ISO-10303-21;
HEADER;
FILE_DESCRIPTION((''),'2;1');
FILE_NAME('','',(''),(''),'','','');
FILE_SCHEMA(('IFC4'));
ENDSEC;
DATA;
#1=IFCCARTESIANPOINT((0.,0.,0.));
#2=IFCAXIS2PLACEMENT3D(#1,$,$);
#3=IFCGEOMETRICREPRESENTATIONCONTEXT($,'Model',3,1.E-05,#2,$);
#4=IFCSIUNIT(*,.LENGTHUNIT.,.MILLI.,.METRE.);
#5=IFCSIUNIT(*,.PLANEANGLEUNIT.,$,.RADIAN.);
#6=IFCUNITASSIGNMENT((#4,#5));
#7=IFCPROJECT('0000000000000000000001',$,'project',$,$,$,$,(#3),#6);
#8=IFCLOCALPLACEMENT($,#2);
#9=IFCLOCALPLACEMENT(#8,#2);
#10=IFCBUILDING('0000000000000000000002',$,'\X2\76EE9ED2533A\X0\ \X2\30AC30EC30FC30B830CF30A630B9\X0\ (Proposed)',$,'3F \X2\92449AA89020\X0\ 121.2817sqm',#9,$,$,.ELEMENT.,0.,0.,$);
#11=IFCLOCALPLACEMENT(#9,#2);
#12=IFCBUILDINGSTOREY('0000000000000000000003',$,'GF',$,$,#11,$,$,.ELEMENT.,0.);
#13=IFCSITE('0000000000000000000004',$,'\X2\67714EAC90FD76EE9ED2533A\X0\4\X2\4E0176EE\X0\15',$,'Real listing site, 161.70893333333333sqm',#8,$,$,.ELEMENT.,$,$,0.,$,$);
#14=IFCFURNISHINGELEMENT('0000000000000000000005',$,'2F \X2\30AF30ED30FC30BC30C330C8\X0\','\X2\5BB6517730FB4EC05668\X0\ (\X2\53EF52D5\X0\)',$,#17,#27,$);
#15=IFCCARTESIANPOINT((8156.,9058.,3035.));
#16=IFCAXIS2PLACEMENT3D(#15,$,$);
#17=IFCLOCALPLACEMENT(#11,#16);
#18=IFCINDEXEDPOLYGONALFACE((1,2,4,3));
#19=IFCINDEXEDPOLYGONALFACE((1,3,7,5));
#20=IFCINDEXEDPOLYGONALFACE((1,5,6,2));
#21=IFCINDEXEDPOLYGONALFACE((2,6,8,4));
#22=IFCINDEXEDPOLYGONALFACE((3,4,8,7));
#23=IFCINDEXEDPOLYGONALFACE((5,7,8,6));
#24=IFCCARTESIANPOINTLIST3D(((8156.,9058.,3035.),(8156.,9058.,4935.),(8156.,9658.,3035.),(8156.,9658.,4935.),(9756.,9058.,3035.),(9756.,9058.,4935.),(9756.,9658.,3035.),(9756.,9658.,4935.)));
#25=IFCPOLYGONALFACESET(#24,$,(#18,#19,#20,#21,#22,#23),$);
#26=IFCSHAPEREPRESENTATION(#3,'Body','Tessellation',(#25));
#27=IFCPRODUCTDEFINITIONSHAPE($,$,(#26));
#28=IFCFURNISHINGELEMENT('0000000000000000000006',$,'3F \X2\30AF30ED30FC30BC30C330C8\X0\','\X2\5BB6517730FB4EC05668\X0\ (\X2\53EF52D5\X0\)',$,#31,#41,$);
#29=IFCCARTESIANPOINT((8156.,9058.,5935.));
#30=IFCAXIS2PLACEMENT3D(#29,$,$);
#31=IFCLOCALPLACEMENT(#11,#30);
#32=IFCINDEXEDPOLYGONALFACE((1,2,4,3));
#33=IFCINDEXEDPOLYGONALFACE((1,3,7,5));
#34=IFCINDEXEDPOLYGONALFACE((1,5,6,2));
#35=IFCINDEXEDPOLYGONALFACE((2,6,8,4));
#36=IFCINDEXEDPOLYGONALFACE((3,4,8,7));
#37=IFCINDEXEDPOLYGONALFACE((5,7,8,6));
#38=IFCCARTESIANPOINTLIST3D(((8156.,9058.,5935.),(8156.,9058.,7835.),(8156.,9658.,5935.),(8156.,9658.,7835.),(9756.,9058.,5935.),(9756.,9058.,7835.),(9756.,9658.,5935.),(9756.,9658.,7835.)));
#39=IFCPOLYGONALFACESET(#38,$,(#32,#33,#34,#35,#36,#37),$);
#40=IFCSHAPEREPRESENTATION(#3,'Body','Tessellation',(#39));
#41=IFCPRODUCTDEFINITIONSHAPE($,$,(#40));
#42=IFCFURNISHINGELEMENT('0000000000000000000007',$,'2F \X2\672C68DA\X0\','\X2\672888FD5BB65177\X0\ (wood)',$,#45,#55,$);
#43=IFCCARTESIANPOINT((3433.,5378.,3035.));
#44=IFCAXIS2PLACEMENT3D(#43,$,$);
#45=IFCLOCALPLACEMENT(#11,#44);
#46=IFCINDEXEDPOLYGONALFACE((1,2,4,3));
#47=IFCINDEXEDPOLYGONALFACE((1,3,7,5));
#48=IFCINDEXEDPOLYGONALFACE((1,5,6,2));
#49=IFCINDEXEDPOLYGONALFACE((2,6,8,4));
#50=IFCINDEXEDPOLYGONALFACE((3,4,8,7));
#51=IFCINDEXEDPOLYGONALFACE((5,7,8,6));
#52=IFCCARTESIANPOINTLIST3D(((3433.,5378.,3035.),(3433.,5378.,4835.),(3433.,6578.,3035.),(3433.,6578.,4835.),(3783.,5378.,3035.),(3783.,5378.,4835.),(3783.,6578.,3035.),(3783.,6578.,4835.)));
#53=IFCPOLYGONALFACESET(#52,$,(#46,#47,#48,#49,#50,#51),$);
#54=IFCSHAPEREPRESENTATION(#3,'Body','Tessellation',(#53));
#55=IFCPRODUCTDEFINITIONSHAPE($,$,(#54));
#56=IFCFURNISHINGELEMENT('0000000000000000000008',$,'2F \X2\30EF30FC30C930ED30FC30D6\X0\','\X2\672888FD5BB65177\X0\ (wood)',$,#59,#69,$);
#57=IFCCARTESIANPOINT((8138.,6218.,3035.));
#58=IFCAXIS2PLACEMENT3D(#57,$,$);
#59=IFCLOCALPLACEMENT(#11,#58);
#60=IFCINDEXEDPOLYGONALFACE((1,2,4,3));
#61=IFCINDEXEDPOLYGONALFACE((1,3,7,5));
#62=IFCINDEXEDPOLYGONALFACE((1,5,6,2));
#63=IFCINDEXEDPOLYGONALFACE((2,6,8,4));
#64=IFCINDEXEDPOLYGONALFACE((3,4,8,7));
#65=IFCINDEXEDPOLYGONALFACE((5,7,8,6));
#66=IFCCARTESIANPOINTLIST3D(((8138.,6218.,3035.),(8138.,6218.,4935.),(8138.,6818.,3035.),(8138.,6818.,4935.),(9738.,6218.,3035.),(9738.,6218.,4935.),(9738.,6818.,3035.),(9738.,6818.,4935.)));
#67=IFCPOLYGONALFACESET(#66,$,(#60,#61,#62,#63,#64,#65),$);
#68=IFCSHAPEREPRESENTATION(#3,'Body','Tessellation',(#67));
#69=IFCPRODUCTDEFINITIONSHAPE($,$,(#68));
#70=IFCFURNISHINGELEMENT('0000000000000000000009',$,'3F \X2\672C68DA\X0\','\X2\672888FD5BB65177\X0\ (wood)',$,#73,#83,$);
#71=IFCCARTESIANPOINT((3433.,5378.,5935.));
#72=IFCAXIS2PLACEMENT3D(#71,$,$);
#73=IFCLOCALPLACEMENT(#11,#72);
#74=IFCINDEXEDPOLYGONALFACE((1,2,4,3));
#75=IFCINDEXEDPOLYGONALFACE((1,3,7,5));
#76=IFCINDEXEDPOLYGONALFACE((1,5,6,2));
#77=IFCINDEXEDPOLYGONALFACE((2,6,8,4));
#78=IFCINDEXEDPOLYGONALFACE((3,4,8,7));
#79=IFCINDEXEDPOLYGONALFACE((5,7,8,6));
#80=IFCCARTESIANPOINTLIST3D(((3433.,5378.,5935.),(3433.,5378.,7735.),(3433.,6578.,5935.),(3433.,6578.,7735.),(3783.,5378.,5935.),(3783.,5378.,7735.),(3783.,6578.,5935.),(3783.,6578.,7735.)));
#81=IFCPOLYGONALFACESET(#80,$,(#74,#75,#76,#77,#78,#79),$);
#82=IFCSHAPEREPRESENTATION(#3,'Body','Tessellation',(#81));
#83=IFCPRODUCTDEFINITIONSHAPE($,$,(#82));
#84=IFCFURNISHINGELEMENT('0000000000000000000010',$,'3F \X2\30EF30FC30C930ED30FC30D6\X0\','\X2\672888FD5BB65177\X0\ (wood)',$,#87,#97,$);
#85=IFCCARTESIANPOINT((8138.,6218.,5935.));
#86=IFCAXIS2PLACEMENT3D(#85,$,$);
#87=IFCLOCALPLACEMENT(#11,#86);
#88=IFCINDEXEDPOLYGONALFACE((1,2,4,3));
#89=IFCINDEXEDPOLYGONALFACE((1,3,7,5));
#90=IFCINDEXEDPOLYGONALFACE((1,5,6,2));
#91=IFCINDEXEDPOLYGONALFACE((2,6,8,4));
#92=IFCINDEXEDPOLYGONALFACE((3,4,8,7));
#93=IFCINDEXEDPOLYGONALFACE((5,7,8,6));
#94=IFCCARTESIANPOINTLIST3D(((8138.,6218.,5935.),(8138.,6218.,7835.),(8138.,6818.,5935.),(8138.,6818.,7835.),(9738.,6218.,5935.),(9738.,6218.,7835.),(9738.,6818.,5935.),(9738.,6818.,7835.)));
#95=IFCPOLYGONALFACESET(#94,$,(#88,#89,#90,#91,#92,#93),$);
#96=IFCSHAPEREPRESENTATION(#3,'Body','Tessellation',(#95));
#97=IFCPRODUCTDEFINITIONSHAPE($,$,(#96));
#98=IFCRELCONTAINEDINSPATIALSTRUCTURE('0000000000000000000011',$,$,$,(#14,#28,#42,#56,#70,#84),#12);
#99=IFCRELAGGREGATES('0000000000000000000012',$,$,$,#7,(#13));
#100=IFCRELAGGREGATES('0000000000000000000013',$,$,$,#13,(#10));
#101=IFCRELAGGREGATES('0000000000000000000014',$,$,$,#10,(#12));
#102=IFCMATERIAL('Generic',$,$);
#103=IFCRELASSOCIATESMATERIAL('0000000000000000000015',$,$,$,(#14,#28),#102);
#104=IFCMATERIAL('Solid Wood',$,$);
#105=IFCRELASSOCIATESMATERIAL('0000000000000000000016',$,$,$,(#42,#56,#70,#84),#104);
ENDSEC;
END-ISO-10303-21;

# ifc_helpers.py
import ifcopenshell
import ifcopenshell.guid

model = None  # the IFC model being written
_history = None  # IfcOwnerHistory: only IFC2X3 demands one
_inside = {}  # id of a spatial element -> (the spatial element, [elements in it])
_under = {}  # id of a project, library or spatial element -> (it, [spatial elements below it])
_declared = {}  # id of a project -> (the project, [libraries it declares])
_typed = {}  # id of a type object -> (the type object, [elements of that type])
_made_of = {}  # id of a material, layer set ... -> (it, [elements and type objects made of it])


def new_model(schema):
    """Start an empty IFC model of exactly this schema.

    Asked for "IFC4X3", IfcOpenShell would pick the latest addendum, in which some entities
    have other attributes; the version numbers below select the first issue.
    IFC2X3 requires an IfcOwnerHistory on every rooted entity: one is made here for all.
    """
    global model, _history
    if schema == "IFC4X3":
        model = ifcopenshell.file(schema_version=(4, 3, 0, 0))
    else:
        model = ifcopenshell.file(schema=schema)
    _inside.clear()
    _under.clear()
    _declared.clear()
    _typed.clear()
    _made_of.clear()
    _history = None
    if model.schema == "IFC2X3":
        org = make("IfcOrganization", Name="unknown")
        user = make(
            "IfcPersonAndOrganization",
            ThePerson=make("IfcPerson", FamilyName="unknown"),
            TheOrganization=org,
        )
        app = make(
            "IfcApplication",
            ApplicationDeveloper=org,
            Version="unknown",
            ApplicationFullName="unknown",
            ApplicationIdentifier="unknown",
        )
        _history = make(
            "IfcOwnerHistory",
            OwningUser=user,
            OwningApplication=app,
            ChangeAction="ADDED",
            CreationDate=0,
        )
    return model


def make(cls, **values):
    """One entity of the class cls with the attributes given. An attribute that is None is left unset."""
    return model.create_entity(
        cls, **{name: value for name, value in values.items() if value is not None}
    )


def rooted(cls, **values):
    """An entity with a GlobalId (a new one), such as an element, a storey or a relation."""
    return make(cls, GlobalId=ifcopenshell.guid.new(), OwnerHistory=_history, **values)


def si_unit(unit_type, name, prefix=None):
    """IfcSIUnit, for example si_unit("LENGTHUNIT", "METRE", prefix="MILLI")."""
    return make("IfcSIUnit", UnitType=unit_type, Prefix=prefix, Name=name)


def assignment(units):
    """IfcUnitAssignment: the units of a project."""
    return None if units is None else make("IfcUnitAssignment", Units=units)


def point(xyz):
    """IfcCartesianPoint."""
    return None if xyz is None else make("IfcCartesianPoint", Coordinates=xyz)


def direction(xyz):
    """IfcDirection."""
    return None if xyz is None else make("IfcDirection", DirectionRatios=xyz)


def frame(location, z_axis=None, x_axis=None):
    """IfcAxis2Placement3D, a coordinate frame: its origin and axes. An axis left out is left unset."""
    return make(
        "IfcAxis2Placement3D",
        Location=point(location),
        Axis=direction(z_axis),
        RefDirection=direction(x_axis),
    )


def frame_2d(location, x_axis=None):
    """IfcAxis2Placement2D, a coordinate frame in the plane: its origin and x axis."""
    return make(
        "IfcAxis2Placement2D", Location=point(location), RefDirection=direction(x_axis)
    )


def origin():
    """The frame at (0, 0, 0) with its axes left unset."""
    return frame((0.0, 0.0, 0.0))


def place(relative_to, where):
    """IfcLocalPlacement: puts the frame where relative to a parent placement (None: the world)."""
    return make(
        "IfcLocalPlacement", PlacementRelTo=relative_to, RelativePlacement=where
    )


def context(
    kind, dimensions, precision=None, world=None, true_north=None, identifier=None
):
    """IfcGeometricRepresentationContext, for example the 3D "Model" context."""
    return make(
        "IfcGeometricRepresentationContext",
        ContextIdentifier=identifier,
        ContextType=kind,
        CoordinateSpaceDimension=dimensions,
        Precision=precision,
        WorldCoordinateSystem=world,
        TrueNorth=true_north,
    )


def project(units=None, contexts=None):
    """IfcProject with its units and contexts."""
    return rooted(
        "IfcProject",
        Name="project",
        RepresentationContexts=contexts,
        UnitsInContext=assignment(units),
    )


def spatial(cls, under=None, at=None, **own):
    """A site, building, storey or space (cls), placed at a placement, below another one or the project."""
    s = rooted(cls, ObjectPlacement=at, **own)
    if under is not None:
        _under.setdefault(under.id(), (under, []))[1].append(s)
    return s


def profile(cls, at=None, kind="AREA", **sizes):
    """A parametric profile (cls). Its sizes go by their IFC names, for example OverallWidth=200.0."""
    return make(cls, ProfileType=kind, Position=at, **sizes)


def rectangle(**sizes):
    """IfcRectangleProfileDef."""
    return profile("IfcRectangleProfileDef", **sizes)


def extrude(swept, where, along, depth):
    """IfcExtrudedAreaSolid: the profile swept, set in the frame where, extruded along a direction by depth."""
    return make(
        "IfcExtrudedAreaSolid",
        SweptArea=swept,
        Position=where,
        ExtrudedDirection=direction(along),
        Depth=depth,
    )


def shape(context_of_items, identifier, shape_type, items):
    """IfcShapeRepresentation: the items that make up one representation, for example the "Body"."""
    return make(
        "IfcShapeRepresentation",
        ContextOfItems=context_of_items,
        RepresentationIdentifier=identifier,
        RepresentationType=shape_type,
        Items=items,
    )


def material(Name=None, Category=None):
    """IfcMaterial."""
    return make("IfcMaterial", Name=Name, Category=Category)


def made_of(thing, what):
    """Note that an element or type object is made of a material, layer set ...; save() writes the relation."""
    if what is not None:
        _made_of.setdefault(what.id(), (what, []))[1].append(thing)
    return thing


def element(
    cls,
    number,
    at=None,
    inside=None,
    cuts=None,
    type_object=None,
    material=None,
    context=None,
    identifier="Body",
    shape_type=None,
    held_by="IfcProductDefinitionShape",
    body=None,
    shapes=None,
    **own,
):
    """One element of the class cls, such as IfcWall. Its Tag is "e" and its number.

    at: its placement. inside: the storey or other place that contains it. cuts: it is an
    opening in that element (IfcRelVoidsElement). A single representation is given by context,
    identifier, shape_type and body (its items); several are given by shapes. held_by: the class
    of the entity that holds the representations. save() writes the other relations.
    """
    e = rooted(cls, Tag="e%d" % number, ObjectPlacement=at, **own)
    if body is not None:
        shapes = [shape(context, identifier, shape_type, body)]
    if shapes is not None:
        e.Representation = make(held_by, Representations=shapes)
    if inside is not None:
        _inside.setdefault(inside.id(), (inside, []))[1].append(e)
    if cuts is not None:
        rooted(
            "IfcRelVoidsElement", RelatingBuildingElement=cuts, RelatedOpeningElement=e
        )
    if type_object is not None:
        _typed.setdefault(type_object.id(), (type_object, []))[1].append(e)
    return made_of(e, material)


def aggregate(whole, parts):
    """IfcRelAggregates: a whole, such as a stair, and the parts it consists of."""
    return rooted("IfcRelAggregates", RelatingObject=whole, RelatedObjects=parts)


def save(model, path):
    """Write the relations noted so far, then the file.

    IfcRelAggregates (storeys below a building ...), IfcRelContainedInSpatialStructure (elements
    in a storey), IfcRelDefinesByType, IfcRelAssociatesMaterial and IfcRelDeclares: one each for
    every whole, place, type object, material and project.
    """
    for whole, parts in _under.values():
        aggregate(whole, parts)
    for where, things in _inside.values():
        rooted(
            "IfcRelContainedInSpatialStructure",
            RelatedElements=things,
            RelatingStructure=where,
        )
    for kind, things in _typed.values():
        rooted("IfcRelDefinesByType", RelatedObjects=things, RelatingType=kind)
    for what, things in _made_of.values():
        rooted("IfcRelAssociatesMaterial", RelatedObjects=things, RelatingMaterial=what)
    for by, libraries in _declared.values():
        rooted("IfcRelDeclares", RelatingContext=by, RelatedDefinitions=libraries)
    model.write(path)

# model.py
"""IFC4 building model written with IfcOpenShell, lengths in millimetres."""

from ifc_helpers import new_model, si_unit, frame, frame_2d, origin, place, context, project, spatial, rectangle, extrude, material, element, save


model = new_model("IFC4")

# Units and contexts
model_context = context("Model", 3, precision=1e-05, world=origin())
ifc_project = project(units=[si_unit("LENGTHUNIT", "METRE", prefix="MILLI"), si_unit("PLANEANGLEUNIT", "RADIAN")], contexts=[model_context])

# Site, building, storey
site_placement = place(None, origin())
site = spatial("IfcSite", under=ifc_project, at=site_placement, Name="東京都目黒区4丁目15", ObjectType="Real listing site, 161.70893333333333sqm", CompositionType="ELEMENT", RefElevation=0.0)
building_placement = place(site_placement, origin())
building = spatial("IfcBuilding", under=site, at=building_placement, Name="目黒区 ガレージハウス (Proposed)", ObjectType="3F 鉄骨造 121.2817sqm", CompositionType="ELEMENT", ElevationOfRefHeight=0.0, ElevationOfTerrain=0.0)
storey_placement = place(building_placement, origin())
storey = spatial("IfcBuildingStorey", under=building, at=storey_placement, Name="GF", CompositionType="ELEMENT", Elevation=0.0)

# Shared definitions
ifc_material_1 = material(Name="Solid Wood")

# Furnishing elements
ifc_material_2 = material(Name="Generic")
furnishing_1_placement = place(storey_placement, frame((8156.0, 9058.0, 3035.0)))
element("IfcFurnishingElement", 1, at=furnishing_1_placement, inside=storey, material=ifc_material_2, Name="2F クローゼット", Description="家具・什器 (可動)", context=model_context, shape_type="SweptSolid", body=[
    extrude(rectangle(XDim=1600.0, YDim=600.0, at=frame_2d((800.0, 300.0))), frame((8156.0, 9058.0, 3035.0)), (0.0, 0.0, 1.0), 1900.0),
])
furnishing_2_placement = place(storey_placement, frame((8156.0, 9058.0, 5935.0)))
element("IfcFurnishingElement", 2, at=furnishing_2_placement, inside=storey, material=ifc_material_2, Name="3F クローゼット", Description="家具・什器 (可動)", context=model_context, shape_type="SweptSolid", body=[
    extrude(rectangle(XDim=1600.0, YDim=600.0, at=frame_2d((800.0, 300.0))), frame((8156.0, 9058.0, 5935.0)), (0.0, 0.0, 1.0), 1900.0),
])
furnishing_3_placement = place(storey_placement, frame((3433.0, 5378.0, 3035.0)))
element("IfcFurnishingElement", 3, at=furnishing_3_placement, inside=storey, material=ifc_material_1, Name="2F 本棚", Description="木製家具 (wood)", context=model_context, shape_type="SweptSolid", body=[
    extrude(rectangle(XDim=350.0, YDim=1200.0, at=frame_2d((175.0, 600.0))), frame((3433.0, 5378.0, 3035.0)), (0.0, 0.0, 1.0), 1800.0),
])
furnishing_4_placement = place(storey_placement, frame((8138.0, 6218.0, 3035.0)))
element("IfcFurnishingElement", 4, at=furnishing_4_placement, inside=storey, material=ifc_material_1, Name="2F ワードローブ", Description="木製家具 (wood)", context=model_context, shape_type="SweptSolid", body=[
    extrude(rectangle(XDim=1600.0, YDim=600.0, at=frame_2d((800.0, 300.0))), frame((8138.0, 6218.0, 3035.0)), (0.0, 0.0, 1.0), 1900.0),
])
furnishing_5_placement = place(storey_placement, frame((3433.0, 5378.0, 5935.0)))
element("IfcFurnishingElement", 5, at=furnishing_5_placement, inside=storey, material=ifc_material_1, Name="3F 本棚", Description="木製家具 (wood)", context=model_context, shape_type="SweptSolid", body=[
    extrude(rectangle(XDim=350.0, YDim=1200.0, at=frame_2d((175.0, 600.0))), frame((3433.0, 5378.0, 5935.0)), (0.0, 0.0, 1.0), 1800.0),
])
furnishing_6_placement = place(storey_placement, frame((8138.0, 6218.0, 5935.0)))
element("IfcFurnishingElement", 6, at=furnishing_6_placement, inside=storey, material=ifc_material_1, Name="3F ワードローブ", Description="木製家具 (wood)", context=model_context, shape_type="SweptSolid", body=[
    extrude(rectangle(XDim=1600.0, YDim=600.0, at=frame_2d((800.0, 300.0))), frame((8138.0, 6218.0, 5935.0)), (0.0, 0.0, 1.0), 1900.0),
])

save(model, "model.ifc")
